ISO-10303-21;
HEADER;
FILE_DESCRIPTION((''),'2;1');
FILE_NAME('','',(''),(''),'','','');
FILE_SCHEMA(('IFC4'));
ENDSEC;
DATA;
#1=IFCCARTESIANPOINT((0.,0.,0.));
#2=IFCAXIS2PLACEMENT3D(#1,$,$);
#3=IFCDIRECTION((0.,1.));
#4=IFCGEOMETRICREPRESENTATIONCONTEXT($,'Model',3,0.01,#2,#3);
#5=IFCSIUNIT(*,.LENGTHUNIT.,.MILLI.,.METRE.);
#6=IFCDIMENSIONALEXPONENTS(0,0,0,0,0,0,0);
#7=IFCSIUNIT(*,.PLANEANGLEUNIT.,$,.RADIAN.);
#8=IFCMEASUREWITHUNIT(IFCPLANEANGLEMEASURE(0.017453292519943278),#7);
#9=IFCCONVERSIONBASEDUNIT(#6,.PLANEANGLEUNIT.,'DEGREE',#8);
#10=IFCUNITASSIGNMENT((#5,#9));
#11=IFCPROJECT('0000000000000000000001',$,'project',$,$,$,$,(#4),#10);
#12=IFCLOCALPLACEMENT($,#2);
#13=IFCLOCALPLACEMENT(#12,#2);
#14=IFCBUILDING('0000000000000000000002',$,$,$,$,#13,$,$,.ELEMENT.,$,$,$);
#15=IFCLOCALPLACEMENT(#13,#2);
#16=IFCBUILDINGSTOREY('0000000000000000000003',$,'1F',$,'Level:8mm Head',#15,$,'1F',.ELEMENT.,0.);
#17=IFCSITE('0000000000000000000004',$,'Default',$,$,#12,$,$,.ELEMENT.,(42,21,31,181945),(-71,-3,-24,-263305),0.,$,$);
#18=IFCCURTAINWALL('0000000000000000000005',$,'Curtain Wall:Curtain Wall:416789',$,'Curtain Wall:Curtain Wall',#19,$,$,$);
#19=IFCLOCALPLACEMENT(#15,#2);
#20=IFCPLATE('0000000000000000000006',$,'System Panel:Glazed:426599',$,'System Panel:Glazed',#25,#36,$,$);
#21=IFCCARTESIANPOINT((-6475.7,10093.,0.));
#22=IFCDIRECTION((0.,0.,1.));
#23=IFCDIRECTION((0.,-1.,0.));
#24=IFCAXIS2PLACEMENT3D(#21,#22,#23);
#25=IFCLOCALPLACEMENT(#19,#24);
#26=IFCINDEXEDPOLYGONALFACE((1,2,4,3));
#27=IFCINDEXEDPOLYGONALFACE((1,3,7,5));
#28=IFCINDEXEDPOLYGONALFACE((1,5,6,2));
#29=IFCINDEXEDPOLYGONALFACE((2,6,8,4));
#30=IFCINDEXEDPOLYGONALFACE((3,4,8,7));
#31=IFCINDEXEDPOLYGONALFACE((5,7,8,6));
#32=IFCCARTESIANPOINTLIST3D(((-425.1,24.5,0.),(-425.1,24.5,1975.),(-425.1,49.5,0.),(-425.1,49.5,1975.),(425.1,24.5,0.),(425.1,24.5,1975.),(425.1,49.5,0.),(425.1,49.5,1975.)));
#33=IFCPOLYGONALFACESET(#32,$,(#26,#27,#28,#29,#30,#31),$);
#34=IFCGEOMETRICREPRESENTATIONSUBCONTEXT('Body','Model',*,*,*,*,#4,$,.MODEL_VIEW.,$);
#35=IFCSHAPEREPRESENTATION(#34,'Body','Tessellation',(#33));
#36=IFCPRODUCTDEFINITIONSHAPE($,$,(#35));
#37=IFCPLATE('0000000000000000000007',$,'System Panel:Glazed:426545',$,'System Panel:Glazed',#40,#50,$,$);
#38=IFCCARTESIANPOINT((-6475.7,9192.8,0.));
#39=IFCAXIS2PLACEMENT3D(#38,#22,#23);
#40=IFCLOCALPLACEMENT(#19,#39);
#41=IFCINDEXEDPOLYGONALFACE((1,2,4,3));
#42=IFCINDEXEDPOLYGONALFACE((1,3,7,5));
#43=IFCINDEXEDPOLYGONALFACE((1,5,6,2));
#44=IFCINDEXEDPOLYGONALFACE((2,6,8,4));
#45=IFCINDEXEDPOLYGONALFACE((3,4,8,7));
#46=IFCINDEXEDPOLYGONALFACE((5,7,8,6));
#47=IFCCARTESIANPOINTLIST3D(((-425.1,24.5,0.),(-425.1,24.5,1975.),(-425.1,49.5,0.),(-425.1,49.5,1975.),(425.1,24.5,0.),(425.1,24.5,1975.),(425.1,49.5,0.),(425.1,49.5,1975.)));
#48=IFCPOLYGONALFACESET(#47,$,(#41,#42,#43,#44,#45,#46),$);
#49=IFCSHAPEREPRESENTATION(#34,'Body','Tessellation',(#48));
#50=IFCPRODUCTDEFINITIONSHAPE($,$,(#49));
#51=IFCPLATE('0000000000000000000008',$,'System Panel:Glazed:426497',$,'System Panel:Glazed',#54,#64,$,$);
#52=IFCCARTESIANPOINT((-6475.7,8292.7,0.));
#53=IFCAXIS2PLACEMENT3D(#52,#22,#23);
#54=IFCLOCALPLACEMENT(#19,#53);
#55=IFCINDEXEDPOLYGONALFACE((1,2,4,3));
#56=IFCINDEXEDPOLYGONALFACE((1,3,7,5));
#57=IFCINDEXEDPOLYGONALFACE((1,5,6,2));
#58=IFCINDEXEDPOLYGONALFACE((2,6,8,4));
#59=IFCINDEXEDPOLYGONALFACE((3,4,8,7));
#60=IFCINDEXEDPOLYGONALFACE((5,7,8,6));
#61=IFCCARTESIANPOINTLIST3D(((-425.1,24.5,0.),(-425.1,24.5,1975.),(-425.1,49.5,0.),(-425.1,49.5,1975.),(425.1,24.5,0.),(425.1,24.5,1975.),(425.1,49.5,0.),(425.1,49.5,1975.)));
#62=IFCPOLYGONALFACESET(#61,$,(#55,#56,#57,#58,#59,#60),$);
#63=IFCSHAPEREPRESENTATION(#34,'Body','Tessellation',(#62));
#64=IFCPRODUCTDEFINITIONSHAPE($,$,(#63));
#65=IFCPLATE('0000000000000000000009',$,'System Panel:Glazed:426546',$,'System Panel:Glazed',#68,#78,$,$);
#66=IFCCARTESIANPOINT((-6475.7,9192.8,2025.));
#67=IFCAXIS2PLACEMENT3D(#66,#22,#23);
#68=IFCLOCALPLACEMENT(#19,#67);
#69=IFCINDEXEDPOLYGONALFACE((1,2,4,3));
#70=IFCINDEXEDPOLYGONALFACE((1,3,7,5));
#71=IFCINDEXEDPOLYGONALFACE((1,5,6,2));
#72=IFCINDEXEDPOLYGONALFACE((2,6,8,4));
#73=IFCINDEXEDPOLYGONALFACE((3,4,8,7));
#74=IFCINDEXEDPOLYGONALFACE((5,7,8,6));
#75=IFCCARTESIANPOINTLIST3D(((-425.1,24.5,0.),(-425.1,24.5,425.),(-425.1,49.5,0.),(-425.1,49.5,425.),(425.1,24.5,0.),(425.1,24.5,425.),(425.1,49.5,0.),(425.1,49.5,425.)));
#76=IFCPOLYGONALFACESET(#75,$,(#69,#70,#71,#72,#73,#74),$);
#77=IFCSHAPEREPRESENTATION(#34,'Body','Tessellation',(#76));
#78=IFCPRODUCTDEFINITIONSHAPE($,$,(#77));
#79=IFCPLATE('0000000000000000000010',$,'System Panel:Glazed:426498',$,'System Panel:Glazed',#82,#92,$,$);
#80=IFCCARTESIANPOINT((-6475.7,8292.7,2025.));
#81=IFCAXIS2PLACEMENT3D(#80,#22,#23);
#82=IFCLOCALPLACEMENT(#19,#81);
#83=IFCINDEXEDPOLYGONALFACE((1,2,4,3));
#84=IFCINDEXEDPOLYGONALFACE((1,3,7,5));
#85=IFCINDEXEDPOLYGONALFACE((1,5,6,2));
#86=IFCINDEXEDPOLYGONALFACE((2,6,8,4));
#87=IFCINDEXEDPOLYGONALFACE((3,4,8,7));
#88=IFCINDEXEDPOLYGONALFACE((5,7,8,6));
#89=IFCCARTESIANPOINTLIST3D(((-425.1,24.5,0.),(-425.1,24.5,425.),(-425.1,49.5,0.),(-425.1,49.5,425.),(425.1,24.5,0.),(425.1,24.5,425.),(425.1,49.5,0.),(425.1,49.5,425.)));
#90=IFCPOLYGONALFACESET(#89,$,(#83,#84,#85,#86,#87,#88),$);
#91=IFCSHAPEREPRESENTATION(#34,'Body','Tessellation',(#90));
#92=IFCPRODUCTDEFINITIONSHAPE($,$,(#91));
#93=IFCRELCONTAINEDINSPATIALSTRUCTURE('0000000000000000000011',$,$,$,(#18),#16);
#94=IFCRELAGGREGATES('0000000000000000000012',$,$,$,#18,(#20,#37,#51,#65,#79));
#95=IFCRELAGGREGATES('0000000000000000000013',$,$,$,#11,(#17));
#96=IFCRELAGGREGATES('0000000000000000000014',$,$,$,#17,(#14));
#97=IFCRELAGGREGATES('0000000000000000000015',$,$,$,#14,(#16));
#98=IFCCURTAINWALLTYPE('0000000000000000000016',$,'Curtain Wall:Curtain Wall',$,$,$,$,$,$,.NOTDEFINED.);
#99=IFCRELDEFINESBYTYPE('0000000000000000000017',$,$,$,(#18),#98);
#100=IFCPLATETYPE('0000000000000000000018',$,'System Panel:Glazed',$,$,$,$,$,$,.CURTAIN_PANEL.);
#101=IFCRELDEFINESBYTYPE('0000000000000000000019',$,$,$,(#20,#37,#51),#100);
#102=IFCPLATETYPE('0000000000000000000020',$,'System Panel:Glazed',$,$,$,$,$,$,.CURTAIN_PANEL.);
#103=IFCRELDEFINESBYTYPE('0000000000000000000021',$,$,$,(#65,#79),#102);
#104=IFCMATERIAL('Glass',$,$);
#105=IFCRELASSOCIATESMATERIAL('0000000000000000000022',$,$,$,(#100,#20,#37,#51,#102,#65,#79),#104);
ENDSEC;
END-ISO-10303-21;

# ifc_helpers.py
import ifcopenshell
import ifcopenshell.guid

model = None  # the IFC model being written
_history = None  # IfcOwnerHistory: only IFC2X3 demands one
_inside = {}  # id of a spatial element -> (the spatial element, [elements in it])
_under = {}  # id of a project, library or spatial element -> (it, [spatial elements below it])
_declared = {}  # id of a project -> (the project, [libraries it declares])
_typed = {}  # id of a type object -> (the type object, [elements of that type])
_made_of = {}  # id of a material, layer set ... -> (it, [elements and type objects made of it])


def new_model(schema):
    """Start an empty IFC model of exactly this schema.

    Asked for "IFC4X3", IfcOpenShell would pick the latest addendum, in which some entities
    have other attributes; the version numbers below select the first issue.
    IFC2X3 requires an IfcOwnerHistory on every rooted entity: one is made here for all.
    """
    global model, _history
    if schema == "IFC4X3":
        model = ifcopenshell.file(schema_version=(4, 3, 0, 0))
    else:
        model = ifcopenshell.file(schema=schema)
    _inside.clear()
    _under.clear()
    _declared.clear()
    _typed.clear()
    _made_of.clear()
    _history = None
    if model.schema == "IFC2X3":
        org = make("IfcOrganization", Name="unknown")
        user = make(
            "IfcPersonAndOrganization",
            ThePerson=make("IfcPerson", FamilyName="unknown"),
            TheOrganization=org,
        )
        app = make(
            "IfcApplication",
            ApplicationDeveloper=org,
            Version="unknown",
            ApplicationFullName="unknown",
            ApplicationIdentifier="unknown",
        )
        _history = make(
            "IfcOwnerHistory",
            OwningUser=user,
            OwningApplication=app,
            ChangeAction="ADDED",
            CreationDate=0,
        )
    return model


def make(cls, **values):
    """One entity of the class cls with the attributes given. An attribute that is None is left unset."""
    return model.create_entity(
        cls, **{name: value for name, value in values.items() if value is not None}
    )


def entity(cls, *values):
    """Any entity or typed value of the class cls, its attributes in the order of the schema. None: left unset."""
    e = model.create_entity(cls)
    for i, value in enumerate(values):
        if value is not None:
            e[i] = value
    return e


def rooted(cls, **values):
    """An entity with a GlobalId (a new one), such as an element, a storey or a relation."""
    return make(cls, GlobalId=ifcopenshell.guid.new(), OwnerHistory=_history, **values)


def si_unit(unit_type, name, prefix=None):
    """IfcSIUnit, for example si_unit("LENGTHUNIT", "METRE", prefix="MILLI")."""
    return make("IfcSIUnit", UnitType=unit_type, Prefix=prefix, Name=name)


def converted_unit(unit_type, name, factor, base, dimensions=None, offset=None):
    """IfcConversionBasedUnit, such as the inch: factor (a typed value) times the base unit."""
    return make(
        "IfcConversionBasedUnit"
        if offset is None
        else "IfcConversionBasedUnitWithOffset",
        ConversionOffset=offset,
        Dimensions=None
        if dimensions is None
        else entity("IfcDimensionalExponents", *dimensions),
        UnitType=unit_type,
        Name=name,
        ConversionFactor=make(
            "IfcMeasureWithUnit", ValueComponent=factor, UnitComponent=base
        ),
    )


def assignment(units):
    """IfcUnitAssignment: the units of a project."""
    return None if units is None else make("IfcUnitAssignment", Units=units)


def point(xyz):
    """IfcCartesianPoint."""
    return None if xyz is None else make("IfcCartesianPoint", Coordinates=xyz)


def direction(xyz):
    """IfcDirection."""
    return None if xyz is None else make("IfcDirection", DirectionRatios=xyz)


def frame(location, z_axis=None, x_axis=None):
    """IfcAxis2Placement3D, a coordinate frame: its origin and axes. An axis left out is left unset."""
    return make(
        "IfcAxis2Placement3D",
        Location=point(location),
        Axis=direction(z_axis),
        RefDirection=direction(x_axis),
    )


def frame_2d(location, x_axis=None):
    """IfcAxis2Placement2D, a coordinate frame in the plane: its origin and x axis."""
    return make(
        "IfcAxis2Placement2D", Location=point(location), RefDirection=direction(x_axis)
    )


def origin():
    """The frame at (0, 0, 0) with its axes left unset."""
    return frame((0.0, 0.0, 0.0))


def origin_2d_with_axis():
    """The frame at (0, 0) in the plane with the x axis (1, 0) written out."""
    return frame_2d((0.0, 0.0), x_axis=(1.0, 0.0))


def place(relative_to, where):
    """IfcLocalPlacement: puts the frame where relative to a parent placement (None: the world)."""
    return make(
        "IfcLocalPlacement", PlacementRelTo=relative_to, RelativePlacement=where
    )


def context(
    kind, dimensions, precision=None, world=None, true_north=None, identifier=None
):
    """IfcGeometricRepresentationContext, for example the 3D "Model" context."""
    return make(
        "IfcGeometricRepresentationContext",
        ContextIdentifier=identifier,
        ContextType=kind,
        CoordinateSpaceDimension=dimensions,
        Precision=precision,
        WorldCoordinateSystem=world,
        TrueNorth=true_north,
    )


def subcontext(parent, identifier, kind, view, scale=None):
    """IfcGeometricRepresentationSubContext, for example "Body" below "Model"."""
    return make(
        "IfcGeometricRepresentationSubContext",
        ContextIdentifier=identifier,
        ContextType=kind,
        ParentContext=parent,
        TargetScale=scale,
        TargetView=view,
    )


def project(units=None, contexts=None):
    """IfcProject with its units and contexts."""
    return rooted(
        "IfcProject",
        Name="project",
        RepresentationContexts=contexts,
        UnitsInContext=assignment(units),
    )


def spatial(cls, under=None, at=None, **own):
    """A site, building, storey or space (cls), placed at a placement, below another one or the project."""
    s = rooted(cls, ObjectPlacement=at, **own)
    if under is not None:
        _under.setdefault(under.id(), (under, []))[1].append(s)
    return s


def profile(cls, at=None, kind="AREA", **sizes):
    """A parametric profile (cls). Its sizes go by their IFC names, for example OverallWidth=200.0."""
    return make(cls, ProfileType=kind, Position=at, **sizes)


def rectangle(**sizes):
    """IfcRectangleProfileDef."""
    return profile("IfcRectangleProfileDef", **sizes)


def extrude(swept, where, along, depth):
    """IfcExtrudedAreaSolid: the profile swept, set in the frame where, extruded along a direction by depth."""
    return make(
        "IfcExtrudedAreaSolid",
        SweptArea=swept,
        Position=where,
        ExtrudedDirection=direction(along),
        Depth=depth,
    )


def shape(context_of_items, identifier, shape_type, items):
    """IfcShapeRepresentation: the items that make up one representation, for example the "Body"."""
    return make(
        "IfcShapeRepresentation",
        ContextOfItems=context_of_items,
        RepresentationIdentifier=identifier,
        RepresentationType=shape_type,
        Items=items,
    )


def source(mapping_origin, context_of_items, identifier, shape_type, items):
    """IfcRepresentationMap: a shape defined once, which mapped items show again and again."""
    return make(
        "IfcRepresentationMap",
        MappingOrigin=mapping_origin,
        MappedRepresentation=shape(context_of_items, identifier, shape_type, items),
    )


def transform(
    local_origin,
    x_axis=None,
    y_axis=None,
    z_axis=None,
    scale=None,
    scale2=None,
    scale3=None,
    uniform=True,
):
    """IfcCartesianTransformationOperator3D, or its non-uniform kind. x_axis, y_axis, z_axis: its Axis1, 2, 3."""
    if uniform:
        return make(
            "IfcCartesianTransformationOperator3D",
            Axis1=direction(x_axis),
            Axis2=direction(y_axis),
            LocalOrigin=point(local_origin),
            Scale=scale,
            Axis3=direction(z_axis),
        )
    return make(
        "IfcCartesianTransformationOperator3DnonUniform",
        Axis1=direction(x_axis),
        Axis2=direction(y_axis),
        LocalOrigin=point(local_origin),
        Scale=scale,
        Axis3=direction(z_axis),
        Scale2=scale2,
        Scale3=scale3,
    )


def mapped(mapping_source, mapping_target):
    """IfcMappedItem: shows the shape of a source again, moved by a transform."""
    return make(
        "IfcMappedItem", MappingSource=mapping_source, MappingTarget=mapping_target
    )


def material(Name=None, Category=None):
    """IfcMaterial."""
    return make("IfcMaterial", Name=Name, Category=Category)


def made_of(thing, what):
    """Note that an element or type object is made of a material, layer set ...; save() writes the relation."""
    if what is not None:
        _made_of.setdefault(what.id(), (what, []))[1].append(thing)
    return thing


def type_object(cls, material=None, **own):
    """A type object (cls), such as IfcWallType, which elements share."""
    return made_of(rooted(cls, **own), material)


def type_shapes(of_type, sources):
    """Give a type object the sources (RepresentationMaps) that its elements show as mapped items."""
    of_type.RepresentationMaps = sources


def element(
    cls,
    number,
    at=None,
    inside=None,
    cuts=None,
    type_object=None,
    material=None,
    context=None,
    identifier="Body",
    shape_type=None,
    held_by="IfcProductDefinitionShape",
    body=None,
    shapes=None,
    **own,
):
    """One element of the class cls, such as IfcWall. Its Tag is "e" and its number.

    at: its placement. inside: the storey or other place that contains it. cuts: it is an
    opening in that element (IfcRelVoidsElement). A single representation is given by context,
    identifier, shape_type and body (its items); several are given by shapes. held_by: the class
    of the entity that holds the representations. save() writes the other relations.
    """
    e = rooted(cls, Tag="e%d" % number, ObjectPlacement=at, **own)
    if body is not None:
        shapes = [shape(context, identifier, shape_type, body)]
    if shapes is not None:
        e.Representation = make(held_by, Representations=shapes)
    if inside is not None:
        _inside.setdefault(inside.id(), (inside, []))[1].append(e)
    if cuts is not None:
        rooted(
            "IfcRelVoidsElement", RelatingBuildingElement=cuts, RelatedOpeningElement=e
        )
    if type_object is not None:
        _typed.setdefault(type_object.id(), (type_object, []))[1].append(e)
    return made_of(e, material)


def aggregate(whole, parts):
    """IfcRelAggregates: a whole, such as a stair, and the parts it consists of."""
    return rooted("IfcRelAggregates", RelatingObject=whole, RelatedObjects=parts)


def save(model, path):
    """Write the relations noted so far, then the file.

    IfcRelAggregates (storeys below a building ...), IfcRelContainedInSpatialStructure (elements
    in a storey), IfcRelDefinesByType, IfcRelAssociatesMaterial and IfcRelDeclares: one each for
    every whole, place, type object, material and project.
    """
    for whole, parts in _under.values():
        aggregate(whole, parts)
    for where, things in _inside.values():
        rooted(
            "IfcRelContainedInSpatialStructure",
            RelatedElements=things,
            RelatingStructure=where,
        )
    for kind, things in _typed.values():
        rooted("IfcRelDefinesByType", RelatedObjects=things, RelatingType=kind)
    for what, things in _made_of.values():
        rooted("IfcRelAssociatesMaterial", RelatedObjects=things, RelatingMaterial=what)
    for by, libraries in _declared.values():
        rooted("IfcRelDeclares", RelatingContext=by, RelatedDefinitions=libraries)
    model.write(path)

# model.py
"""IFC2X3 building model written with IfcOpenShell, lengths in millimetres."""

from ifc_helpers import new_model, entity, si_unit, converted_unit, direction, frame, origin, origin_2d_with_axis, place, context, subcontext, project, spatial, rectangle, extrude, source, transform, mapped, material, type_object, type_shapes, element, aggregate, save


model = new_model("IFC2X3")

# Units and contexts
model_context = context("Model", 3, precision=0.01, world=origin(), true_north=direction((0.0, 1.0)))
body_context = subcontext(model_context, "Body", "Model", "MODEL_VIEW")
ifc_project = project(units=[si_unit("LENGTHUNIT", "METRE", prefix="MILLI"), converted_unit("PLANEANGLEUNIT", "DEGREE", entity("IfcPlaneAngleMeasure", 0.017453292519943278), si_unit("PLANEANGLEUNIT", "RADIAN"), dimensions=[0, 0, 0, 0, 0, 0, 0])], contexts=[model_context])

# Site, building, storey
site_placement = place(None, origin())
site = spatial("IfcSite", under=ifc_project, at=site_placement, Name="Default", CompositionType="ELEMENT", RefLatitude=(42, 21, 31, 181945), RefLongitude=(-71, -3, -24, -263305), RefElevation=0.0)
building_placement = place(site_placement, origin())
building = spatial("IfcBuilding", under=site, at=building_placement, CompositionType="ELEMENT")
storey_placement = place(building_placement, origin())
storey = spatial("IfcBuildingStorey", under=building, at=storey_placement, Name="1F", ObjectType="Level:8mm Head", LongName="1F", CompositionType="ELEMENT", Elevation=0.0)

# Curtain wall, plates
curtain_wall_type = type_object("IfcCurtainWallType", Name="Curtain Wall:Curtain Wall", PredefinedType="NOTDEFINED")
curtain_wall_placement = place(storey_placement, origin())
curtain_wall = element("IfcCurtainWall", 1, at=curtain_wall_placement, inside=storey, type_object=curtain_wall_type, Name="Curtain Wall:Curtain Wall:416789", ObjectType="Curtain Wall:Curtain Wall")
ifc_material_1 = material(Name="Glass")
plate_type_1 = type_object("IfcPlateType", Name="System Panel:Glazed", PredefinedType="CURTAIN_PANEL", material=ifc_material_1)
shared_shape_1 = source(origin(), body_context, "Body", "SweptSolid", [
    extrude(rectangle(XDim=25.0, YDim=850.2, at=origin_2d_with_axis()), frame((0.0, 37.0, 0.0), z_axis=(0.0, 0.0, 1.0), x_axis=(0.0, 1.0, 0.0)), (0.0, 0.0, 1.0), 1975.0),
])
type_shapes(plate_type_1, [shared_shape_1])
plate_1_placement = place(curtain_wall_placement, frame((-6475.7, 10093.0, 0.0), z_axis=(0.0, 0.0, 1.0), x_axis=(0.0, -1.0, 0.0)))
plate_1 = element("IfcPlate", 2, at=plate_1_placement, type_object=plate_type_1, material=ifc_material_1, Name="System Panel:Glazed:426599", ObjectType="System Panel:Glazed", context=body_context, shape_type="MappedRepresentation", body=[
    mapped(shared_shape_1, transform((0.0, 0.0, 0.0), scale=1.0)),
])
plate_2_placement = place(curtain_wall_placement, frame((-6475.7, 9192.8, 0.0), z_axis=(0.0, 0.0, 1.0), x_axis=(0.0, -1.0, 0.0)))
plate_2 = element("IfcPlate", 3, at=plate_2_placement, type_object=plate_type_1, material=ifc_material_1, Name="System Panel:Glazed:426545", ObjectType="System Panel:Glazed", context=body_context, shape_type="MappedRepresentation", body=[
    mapped(shared_shape_1, transform((0.0, 0.0, 0.0), scale=1.0)),
])
plate_3_placement = place(curtain_wall_placement, frame((-6475.7, 8292.7, 0.0), z_axis=(0.0, 0.0, 1.0), x_axis=(0.0, -1.0, 0.0)))
plate_3 = element("IfcPlate", 4, at=plate_3_placement, type_object=plate_type_1, material=ifc_material_1, Name="System Panel:Glazed:426497", ObjectType="System Panel:Glazed", context=body_context, shape_type="MappedRepresentation", body=[
    mapped(shared_shape_1, transform((0.0, 0.0, 0.0), scale=1.0)),
])
plate_type_2 = type_object("IfcPlateType", Name="System Panel:Glazed", PredefinedType="CURTAIN_PANEL", material=ifc_material_1)
shared_shape_2 = source(origin(), body_context, "Body", "SweptSolid", [
    extrude(rectangle(XDim=25.0, YDim=850.2, at=origin_2d_with_axis()), frame((0.0, 37.0, 0.0), z_axis=(0.0, 0.0, 1.0), x_axis=(0.0, 1.0, 0.0)), (0.0, 0.0, 1.0), 425.0),
])
type_shapes(plate_type_2, [shared_shape_2])
plate_4_placement = place(curtain_wall_placement, frame((-6475.7, 9192.8, 2025.0), z_axis=(0.0, 0.0, 1.0), x_axis=(0.0, -1.0, 0.0)))
plate_4 = element("IfcPlate", 5, at=plate_4_placement, type_object=plate_type_2, material=ifc_material_1, Name="System Panel:Glazed:426546", ObjectType="System Panel:Glazed", context=body_context, shape_type="MappedRepresentation", body=[
    mapped(shared_shape_2, transform((0.0, 0.0, 0.0), scale=1.0)),
])
plate_5_placement = place(curtain_wall_placement, frame((-6475.7, 8292.7, 2025.0), z_axis=(0.0, 0.0, 1.0), x_axis=(0.0, -1.0, 0.0)))
plate_5 = element("IfcPlate", 6, at=plate_5_placement, type_object=plate_type_2, material=ifc_material_1, Name="System Panel:Glazed:426498", ObjectType="System Panel:Glazed", context=body_context, shape_type="MappedRepresentation", body=[
    mapped(shared_shape_2, transform((0.0, 0.0, 0.0), scale=1.0)),
])
aggregate(curtain_wall, [plate_1, plate_2, plate_3, plate_4, plate_5])

save(model, "model.ifc")
